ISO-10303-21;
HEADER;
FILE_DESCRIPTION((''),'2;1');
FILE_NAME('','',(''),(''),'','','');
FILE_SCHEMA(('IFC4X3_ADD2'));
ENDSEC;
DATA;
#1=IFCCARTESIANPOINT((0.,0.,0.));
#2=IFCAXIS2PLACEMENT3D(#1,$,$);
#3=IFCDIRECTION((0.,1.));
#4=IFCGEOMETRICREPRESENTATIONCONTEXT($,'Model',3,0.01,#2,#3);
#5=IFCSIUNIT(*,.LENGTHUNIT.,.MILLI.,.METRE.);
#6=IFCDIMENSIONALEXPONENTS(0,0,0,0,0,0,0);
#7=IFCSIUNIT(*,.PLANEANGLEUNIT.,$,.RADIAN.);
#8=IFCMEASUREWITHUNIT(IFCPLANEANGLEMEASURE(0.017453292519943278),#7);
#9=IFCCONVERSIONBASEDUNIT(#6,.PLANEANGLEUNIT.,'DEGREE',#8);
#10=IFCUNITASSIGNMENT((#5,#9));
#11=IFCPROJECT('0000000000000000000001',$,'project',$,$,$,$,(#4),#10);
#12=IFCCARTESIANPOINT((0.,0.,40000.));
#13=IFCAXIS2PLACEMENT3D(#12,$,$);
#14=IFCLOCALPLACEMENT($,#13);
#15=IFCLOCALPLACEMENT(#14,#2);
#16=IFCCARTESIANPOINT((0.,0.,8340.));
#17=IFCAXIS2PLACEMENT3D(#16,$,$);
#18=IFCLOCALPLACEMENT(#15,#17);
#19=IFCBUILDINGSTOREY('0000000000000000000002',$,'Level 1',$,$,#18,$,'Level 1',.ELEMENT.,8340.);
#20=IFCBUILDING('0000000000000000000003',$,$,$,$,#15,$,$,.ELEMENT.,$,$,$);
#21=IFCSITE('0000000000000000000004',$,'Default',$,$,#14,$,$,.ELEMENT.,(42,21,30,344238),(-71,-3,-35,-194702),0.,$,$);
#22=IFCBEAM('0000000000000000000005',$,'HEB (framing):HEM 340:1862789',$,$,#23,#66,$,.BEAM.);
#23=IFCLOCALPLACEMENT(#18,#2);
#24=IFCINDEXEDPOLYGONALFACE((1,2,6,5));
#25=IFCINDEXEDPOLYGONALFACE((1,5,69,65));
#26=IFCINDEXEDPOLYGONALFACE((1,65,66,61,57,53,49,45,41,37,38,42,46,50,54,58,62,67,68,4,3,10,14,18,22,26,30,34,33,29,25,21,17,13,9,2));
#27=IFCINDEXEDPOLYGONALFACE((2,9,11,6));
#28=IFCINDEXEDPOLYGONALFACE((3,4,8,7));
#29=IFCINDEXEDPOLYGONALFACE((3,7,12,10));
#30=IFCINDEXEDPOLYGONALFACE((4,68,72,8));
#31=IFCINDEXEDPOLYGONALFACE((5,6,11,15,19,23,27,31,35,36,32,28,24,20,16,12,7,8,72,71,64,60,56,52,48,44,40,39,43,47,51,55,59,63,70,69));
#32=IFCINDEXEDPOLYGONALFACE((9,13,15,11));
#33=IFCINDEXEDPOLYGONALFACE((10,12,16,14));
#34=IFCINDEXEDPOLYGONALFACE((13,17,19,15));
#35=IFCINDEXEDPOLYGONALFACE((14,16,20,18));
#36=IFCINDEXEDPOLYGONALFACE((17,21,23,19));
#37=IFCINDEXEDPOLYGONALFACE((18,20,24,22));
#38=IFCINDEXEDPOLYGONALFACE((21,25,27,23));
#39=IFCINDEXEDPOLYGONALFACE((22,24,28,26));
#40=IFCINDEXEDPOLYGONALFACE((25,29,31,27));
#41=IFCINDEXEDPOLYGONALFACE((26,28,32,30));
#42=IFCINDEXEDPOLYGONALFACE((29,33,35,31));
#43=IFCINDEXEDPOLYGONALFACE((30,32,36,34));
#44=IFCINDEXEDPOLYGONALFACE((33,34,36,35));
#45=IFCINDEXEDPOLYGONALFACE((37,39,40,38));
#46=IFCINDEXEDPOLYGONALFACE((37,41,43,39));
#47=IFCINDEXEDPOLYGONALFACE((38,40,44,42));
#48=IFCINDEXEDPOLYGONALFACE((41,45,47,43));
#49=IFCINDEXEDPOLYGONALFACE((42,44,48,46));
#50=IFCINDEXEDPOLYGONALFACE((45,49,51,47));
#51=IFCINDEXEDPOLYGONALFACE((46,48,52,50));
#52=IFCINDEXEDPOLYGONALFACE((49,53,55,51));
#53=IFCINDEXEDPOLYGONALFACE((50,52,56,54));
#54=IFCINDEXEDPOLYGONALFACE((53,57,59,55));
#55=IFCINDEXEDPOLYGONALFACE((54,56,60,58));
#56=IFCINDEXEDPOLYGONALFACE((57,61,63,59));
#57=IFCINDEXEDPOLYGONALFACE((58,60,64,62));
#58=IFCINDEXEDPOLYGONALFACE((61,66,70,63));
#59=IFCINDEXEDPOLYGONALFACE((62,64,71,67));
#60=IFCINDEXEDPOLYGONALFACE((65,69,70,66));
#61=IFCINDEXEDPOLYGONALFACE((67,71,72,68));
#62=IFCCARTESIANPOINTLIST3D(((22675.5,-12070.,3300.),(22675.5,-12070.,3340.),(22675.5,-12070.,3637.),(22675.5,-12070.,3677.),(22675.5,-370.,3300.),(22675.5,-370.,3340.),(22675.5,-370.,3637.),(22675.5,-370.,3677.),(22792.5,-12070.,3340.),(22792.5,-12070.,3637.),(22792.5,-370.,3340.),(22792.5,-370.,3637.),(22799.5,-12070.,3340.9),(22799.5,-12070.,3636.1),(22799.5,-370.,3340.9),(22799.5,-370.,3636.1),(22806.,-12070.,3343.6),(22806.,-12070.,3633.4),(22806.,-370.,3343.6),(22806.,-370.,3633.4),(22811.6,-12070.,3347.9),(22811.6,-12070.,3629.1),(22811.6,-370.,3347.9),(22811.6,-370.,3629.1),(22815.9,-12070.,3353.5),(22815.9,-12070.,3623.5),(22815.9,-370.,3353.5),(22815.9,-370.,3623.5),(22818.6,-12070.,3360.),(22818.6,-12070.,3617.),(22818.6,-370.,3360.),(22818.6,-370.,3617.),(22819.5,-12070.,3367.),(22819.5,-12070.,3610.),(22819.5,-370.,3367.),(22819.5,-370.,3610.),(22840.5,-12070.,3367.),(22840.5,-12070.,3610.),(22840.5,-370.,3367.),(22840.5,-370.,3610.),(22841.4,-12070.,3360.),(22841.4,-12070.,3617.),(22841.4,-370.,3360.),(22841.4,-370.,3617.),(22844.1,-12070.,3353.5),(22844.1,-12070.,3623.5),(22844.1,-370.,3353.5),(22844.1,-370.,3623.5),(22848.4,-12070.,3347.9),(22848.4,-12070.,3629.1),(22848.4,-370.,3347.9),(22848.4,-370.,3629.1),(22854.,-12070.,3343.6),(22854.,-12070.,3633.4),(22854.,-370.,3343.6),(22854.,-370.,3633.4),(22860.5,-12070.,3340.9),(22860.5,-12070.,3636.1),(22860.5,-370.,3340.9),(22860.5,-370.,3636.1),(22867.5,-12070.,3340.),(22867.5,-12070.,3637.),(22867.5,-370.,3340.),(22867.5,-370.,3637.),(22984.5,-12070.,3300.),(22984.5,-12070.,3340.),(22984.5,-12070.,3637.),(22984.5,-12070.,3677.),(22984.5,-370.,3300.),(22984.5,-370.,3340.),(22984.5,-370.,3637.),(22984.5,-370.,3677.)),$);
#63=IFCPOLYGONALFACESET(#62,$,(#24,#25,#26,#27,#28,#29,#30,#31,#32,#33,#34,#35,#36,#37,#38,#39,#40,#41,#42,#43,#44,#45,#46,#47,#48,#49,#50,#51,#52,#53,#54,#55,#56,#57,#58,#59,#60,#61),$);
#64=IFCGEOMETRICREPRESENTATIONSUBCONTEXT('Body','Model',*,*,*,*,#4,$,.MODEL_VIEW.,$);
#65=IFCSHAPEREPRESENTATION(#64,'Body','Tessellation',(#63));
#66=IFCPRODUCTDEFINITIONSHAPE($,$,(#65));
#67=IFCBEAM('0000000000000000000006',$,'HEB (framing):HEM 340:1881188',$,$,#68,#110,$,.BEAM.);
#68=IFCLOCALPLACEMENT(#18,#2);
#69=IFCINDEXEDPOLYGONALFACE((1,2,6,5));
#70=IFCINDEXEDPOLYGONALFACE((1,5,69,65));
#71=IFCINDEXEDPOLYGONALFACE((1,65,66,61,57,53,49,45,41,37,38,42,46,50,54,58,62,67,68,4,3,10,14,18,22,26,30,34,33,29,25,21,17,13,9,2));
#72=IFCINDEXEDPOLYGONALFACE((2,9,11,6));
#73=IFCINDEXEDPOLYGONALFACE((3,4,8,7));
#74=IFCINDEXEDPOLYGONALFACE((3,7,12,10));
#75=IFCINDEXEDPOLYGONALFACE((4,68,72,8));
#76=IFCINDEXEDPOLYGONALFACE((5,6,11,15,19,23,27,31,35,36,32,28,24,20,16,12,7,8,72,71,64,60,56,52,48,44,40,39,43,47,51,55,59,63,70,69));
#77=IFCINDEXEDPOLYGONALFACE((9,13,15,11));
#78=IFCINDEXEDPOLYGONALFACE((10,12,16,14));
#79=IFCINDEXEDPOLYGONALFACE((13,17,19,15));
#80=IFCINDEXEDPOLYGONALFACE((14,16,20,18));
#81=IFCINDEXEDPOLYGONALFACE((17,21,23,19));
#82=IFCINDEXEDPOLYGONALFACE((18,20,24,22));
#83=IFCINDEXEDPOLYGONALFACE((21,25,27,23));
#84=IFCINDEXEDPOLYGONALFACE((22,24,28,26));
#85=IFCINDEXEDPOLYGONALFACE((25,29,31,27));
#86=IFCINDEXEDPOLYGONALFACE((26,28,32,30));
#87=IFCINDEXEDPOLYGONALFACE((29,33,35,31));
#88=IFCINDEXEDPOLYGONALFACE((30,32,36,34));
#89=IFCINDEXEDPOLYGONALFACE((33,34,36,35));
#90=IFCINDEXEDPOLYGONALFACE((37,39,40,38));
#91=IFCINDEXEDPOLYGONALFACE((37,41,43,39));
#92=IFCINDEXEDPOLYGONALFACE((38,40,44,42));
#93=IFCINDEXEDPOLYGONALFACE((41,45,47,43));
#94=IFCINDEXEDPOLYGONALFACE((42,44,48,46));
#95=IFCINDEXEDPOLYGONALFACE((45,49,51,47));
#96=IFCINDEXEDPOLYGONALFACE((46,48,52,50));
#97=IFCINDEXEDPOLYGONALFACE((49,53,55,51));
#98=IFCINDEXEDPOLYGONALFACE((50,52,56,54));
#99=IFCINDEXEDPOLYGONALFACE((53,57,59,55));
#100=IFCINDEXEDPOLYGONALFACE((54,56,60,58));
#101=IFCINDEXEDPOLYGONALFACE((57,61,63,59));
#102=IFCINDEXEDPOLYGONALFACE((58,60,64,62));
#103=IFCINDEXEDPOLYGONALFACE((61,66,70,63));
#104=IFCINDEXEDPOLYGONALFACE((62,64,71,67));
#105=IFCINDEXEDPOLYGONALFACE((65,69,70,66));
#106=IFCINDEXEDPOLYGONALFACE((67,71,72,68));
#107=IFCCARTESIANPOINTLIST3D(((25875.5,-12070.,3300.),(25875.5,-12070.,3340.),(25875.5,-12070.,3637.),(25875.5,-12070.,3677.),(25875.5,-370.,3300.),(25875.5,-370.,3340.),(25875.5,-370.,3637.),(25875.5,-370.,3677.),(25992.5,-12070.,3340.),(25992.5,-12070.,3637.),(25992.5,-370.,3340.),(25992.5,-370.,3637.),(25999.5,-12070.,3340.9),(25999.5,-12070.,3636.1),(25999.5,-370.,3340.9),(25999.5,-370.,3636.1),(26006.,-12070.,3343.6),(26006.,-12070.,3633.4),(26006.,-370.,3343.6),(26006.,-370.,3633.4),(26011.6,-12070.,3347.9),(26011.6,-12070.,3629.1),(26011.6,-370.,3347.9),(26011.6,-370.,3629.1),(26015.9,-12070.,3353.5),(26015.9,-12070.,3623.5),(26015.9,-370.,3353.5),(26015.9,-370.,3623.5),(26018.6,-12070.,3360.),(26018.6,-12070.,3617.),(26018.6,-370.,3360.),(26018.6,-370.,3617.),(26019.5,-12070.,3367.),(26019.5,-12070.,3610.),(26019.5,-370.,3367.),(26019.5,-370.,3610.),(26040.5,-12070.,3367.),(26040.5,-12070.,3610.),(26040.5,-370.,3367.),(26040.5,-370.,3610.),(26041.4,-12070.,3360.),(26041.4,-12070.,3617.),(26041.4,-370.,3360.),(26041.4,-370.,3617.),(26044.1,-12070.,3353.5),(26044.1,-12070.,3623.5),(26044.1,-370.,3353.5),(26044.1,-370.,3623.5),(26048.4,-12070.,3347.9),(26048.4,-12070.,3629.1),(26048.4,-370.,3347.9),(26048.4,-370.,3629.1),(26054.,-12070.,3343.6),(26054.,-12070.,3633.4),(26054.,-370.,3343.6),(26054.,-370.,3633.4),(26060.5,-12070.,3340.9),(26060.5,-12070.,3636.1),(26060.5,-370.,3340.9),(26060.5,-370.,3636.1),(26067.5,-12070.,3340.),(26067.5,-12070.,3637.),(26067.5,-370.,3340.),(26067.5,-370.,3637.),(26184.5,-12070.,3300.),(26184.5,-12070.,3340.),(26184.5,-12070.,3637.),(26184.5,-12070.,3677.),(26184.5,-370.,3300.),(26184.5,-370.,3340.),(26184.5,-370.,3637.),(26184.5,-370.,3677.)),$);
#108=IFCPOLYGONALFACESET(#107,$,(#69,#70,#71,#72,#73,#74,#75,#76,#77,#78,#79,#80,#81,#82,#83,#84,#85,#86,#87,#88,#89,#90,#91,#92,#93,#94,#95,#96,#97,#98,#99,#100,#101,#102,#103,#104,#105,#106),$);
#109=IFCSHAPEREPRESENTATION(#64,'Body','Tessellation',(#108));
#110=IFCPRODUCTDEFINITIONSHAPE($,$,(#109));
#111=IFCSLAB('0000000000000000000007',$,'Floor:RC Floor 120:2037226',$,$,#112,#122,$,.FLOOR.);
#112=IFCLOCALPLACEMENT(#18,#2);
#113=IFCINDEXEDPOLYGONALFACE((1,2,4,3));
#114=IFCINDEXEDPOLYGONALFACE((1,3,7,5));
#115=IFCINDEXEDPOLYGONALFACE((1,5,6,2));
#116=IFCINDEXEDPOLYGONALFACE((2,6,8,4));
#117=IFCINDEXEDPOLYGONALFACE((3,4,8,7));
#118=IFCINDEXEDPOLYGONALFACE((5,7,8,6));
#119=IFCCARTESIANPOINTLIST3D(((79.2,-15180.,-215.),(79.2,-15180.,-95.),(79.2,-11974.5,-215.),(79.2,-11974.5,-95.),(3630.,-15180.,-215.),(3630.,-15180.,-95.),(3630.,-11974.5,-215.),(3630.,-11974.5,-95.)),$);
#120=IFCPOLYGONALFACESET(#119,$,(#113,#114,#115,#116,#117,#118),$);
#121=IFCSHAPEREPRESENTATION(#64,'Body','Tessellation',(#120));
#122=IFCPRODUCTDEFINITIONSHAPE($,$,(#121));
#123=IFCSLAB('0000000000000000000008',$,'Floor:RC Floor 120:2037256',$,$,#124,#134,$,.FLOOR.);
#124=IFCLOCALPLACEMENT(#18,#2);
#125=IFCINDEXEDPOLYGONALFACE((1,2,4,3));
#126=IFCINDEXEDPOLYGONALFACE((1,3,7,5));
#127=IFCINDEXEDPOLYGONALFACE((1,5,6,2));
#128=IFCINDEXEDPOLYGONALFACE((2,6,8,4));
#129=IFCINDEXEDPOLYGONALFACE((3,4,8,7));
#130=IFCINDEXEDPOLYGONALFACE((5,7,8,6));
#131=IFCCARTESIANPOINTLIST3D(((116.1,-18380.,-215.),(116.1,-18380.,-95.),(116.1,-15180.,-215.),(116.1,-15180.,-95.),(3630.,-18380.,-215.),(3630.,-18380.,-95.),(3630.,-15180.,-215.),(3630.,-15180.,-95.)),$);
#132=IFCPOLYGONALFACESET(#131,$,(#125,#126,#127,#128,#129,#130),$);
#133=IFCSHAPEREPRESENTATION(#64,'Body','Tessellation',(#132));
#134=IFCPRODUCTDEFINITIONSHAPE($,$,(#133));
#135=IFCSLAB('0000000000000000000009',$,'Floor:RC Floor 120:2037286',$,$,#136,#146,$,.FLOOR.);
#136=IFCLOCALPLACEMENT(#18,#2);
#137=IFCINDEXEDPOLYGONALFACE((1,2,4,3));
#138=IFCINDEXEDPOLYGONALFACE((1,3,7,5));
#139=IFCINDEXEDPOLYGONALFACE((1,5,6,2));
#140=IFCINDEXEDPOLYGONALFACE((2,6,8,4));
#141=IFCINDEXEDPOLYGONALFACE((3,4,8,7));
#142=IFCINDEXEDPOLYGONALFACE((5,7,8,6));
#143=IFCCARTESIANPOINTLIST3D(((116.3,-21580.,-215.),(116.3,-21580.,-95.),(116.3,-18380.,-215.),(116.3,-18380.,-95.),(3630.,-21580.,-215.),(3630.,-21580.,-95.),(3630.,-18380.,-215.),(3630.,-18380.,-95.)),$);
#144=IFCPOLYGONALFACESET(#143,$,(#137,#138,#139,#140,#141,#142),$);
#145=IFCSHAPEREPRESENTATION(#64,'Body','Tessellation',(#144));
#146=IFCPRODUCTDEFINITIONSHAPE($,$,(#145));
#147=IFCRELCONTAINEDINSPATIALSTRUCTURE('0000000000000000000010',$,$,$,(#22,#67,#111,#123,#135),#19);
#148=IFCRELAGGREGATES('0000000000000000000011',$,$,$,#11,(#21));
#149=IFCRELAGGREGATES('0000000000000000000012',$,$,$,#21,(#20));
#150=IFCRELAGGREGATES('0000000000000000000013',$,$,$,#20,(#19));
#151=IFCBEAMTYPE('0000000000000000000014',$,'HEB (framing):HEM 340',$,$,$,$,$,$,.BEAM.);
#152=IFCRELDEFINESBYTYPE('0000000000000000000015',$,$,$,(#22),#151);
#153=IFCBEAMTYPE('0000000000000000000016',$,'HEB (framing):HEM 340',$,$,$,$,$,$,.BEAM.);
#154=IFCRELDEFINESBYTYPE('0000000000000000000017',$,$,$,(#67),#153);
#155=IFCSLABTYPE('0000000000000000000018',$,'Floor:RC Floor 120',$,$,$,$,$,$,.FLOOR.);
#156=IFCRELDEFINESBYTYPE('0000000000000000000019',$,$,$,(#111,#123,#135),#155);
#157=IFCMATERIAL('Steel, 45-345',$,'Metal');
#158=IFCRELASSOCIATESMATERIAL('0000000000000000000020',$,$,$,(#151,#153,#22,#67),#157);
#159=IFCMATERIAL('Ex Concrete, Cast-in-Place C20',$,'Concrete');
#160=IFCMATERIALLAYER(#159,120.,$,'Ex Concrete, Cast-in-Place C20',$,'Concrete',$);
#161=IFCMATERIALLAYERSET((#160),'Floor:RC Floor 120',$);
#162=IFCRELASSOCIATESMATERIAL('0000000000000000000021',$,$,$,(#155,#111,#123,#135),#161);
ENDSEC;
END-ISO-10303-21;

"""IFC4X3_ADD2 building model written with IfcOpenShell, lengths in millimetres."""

from ifc_helpers import new_model, entity, si_unit, converted_unit, direction, frame, frame_2d, origin, origin_2d_with_axis, place, context, subcontext, project, spatial, polyline, circle_curve, parameter, trimmed, segment, composite_curve, rectangle, outline, extrude, source, transform, mapped, material, layer, layer_set, layer_usage, material_profile, profile_set, profile_usage, type_object, type_shapes, element, save


model = new_model("IFC4X3_ADD2")

# Units and contexts
model_context = context("Model", 3, precision=0.01, world=origin(), true_north=direction((0.0, 1.0)))
body_context = subcontext(model_context, "Body", "Model", "MODEL_VIEW")
ifc_project = project(units=[si_unit("LENGTHUNIT", "METRE", prefix="MILLI"), converted_unit("PLANEANGLEUNIT", "DEGREE", entity("IfcPlaneAngleMeasure", 0.017453292519943278), si_unit("PLANEANGLEUNIT", "RADIAN"), dimensions=[0, 0, 0, 0, 0, 0, 0])], contexts=[model_context])

# Site, building, storey
site_placement = place(None, frame((0.0, 0.0, 40000.0)))
site = spatial("IfcSite", under=ifc_project, at=site_placement, Name="Default", CompositionType="ELEMENT", RefLatitude=(42, 21, 30, 344238), RefLongitude=(-71, -3, -35, -194702), RefElevation=0.0)
building_placement = place(site_placement, origin())
building = spatial("IfcBuilding", under=site, at=building_placement, CompositionType="ELEMENT")
storey_placement = place(building_placement, frame((0.0, 0.0, 8340.0)))
storey = spatial("IfcBuildingStorey", under=building, at=storey_placement, Name="Level 1", LongName="Level 1", CompositionType="ELEMENT", Elevation=8340.0)

# Shared definitions
ifc_material_1 = material(Name="Steel, 45-345", Category="Metal")

# Beams
ifc_material_profile_1 = material_profile(ifc_material_1, outline(composite_curve([segment(polyline([(-154.5, -148.5), (-154.5, -188.5)]), True, "CONTINUOUS"), segment(polyline([(-154.5, -188.5), (154.5, -188.5)]), True, "CONTINUOUS"), segment(polyline([(154.5, -188.5), (154.5, -148.5)]), True, "CONTINUOUS"), segment(polyline([(154.5, -148.5), (37.5, -148.5)]), True, "CONTINUOUS"), segment(trimmed(circle_curve(frame_2d((37.5, -121.5), x_axis=(1.0, 0.0)), 27.0), [parameter(180.0)], [parameter(270.0)], True, "PARAMETER"), False, "CONTINUOUS"), segment(polyline([(10.5, -121.5), (10.5, 121.5)]), True, "CONTINUOUS"), segment(trimmed(circle_curve(frame_2d((37.5, 121.5), x_axis=(1.0, 0.0)), 27.0), [parameter(90.0)], [parameter(180.0)], True, "PARAMETER"), False, "CONTINUOUS"), segment(polyline([(37.5, 148.5), (154.5, 148.5)]), True, "CONTINUOUS"), segment(polyline([(154.5, 148.5), (154.5, 188.5)]), True, "CONTINUOUS"), segment(polyline([(154.5, 188.5), (-154.5, 188.5)]), True, "CONTINUOUS"), segment(polyline([(-154.5, 188.5), (-154.5, 148.5)]), True, "CONTINUOUS"), segment(polyline([(-154.5, 148.5), (-37.5, 148.5)]), True, "CONTINUOUS"), segment(trimmed(circle_curve(frame_2d((-37.5, 121.5), x_axis=(1.0, 0.0)), 27.0), [parameter(360.0)], [parameter(90.0)], True, "PARAMETER"), False, "CONTINUOUS"), segment(polyline([(-10.5, 121.5), (-10.5, -121.5)]), True, "CONTINUOUS"), segment(trimmed(circle_curve(frame_2d((-37.5, -121.5), x_axis=(1.0, 0.0)), 27.0), [parameter(270.0)], [parameter(0.0)], True, "PARAMETER"), False, "CONTINUOUS"), segment(polyline([(-37.5, -148.5), (-154.5, -148.5)]), True, "CONTINUOUS")], self_intersect=False)), Name="HEM 340")
ifc_profile_set_1 = profile_set([ifc_material_profile_1], Name="HEM 340")
ifc_profile_usage_1 = profile_usage(ifc_profile_set_1, cardinal=8)
beam_type_1 = type_object("IfcBeamType", Name="HEB (framing):HEM 340", PredefinedType="BEAM", material=ifc_profile_set_1)
shared_shape_1 = source(origin(), body_context, "Body", "SweptSolid", [
    extrude(outline(composite_curve([segment(polyline([(-154.5, -148.5), (-154.5, -188.5)]), True, "CONTINUOUS"), segment(polyline([(-154.5, -188.5), (154.5, -188.5)]), True, "CONTINUOUS"), segment(polyline([(154.5, -188.5), (154.5, -148.5)]), True, "CONTINUOUS"), segment(polyline([(154.5, -148.5), (37.5, -148.5)]), True, "CONTINUOUS"), segment(trimmed(circle_curve(frame_2d((37.5, -121.5), x_axis=(1.0, 0.0)), 27.0), [parameter(180.0)], [parameter(270.0)], True, "PARAMETER"), False, "CONTINUOUS"), segment(polyline([(10.5, -121.5), (10.5, 121.5)]), True, "CONTINUOUS"), segment(trimmed(circle_curve(frame_2d((37.5, 121.5), x_axis=(1.0, 0.0)), 27.0), [parameter(90.0)], [parameter(180.0)], True, "PARAMETER"), False, "CONTINUOUS"), segment(polyline([(37.5, 148.5), (154.5, 148.5)]), True, "CONTINUOUS"), segment(polyline([(154.5, 148.5), (154.5, 188.5)]), True, "CONTINUOUS"), segment(polyline([(154.5, 188.5), (-154.5, 188.5)]), True, "CONTINUOUS"), segment(polyline([(-154.5, 188.5), (-154.5, 148.5)]), True, "CONTINUOUS"), segment(polyline([(-154.5, 148.5), (-37.5, 148.5)]), True, "CONTINUOUS"), segment(trimmed(circle_curve(frame_2d((-37.5, 121.5), x_axis=(1.0, 0.0)), 27.0), [parameter(360.0)], [parameter(90.0)], True, "PARAMETER"), False, "CONTINUOUS"), segment(polyline([(-10.5, 121.5), (-10.5, -121.5)]), True, "CONTINUOUS"), segment(trimmed(circle_curve(frame_2d((-37.5, -121.5), x_axis=(1.0, 0.0)), 27.0), [parameter(270.0)], [parameter(0.0)], True, "PARAMETER"), False, "CONTINUOUS"), segment(polyline([(-37.5, -148.5), (-154.5, -148.5)]), True, "CONTINUOUS")], self_intersect=False)), frame((-5850.0, 0.0, 0.0), z_axis=(-1.0, 0.0, 0.0), x_axis=(0.0, -1.0, 0.0)), (0.0, 0.0, -1.0), 11700.0),
])
type_shapes(beam_type_1, [shared_shape_1])
for number, where, z_axis, x_axis, name in (
    (1, (22830.0, -6220.0, 3488.5), (0.0, 0.0, 1.0), (0.0, -1.0, 0.0), "HEB (framing):HEM 340:1862789"),
):
    element("IfcBeam", number, at=place(storey_placement, frame(where, z_axis=z_axis, x_axis=x_axis)), inside=storey, type_object=beam_type_1, material=ifc_profile_usage_1, Name=name, PredefinedType="BEAM", context=body_context, shape_type="MappedRepresentation", body=[
        mapped(shared_shape_1, transform((0.0, 0.0, 0.0), scale=1.0)),
    ])
beam_type_2 = type_object("IfcBeamType", Name="HEB (framing):HEM 340", PredefinedType="BEAM", material=ifc_profile_set_1)
shared_shape_2 = source(origin(), body_context, "Body", "SweptSolid", [
    extrude(outline(composite_curve([segment(polyline([(-154.5, -148.5), (-154.5, -188.5)]), True, "CONTINUOUS"), segment(polyline([(-154.5, -188.5), (154.5, -188.5)]), True, "CONTINUOUS"), segment(polyline([(154.5, -188.5), (154.5, -148.5)]), True, "CONTINUOUS"), segment(polyline([(154.5, -148.5), (37.5, -148.5)]), True, "CONTINUOUS"), segment(trimmed(circle_curve(frame_2d((37.5, -121.5), x_axis=(1.0, 0.0)), 27.0), [parameter(180.0)], [parameter(270.0)], True, "PARAMETER"), False, "CONTINUOUS"), segment(polyline([(10.5, -121.5), (10.5, 121.5)]), True, "CONTINUOUS"), segment(trimmed(circle_curve(frame_2d((37.5, 121.5), x_axis=(1.0, 0.0)), 27.0), [parameter(90.0)], [parameter(180.0)], True, "PARAMETER"), False, "CONTINUOUS"), segment(polyline([(37.5, 148.5), (154.5, 148.5)]), True, "CONTINUOUS"), segment(polyline([(154.5, 148.5), (154.5, 188.5)]), True, "CONTINUOUS"), segment(polyline([(154.5, 188.5), (-154.5, 188.5)]), True, "CONTINUOUS"), segment(polyline([(-154.5, 188.5), (-154.5, 148.5)]), True, "CONTINUOUS"), segment(polyline([(-154.5, 148.5), (-37.5, 148.5)]), True, "CONTINUOUS"), segment(trimmed(circle_curve(frame_2d((-37.5, 121.5), x_axis=(1.0, 0.0)), 27.0), [parameter(360.0)], [parameter(90.0)], True, "PARAMETER"), False, "CONTINUOUS"), segment(polyline([(-10.5, 121.5), (-10.5, -121.5)]), True, "CONTINUOUS"), segment(trimmed(circle_curve(frame_2d((-37.5, -121.5), x_axis=(1.0, 0.0)), 27.0), [parameter(270.0)], [parameter(0.0)], True, "PARAMETER"), False, "CONTINUOUS"), segment(polyline([(-37.5, -148.5), (-154.5, -148.5)]), True, "CONTINUOUS")], self_intersect=False)), frame((-5850.0, 0.0, 0.0), z_axis=(-1.0, 0.0, 0.0), x_axis=(0.0, -1.0, 0.0)), (0.0, 0.0, -1.0), 11700.0),
])
type_shapes(beam_type_2, [shared_shape_2])
beam_placement = place(storey_placement, frame((26030.0, -6220.0, 3488.5), z_axis=(0.0, 0.0, 1.0), x_axis=(0.0, -1.0, 0.0)))
element("IfcBeam", 2, at=beam_placement, inside=storey, type_object=beam_type_2, material=ifc_profile_usage_1, Name="HEB (framing):HEM 340:1881188", PredefinedType="BEAM", context=body_context, shape_type="MappedRepresentation", body=[
    mapped(shared_shape_2, transform((0.0, 0.0, 0.0), scale=1.0)),
])

# Slabs
ifc_material_2 = material(Name="Ex Concrete, Cast-in-Place C20", Category="Concrete")
ifc_layer_1 = layer(ifc_material_2, 120.0, Name="Ex Concrete, Cast-in-Place C20", Category="Concrete")
ifc_layer_set_1 = layer_set([ifc_layer_1], Name="Floor:RC Floor 120")
ifc_layer_usage_1 = layer_usage(ifc_layer_set_1, "AXIS3", "POSITIVE", 0.0)
slab_type_1 = type_object("IfcSlabType", Name="Floor:RC Floor 120", PredefinedType="FLOOR", material=ifc_layer_set_1)
slab_1_placement = place(storey_placement, origin())
element("IfcSlab", 3, at=slab_1_placement, inside=storey, type_object=slab_type_1, material=ifc_layer_usage_1, Name="Floor:RC Floor 120:2037226", PredefinedType="FLOOR", context=body_context, shape_type="SweptSolid", body=[
    extrude(rectangle(XDim=3205.5, YDim=3550.8, at=frame_2d((0.0, 0.0), x_axis=(1.0, 0.0))), frame((1854.6, -13577.3, -95.0), z_axis=(0.0, 0.0, -1.0), x_axis=(0.0, 1.0, 0.0)), (0.0, 0.0, 1.0), 120.0),
])
ifc_layer_usage_2 = layer_usage(ifc_layer_set_1, "AXIS3", "POSITIVE", 0.0)
slab_2_placement = place(storey_placement, origin())
element("IfcSlab", 4, at=slab_2_placement, inside=storey, type_object=slab_type_1, material=ifc_layer_usage_2, Name="Floor:RC Floor 120:2037256", PredefinedType="FLOOR", context=body_context, shape_type="SweptSolid", body=[
    extrude(rectangle(XDim=3200.0, YDim=3513.9, at=frame_2d((0.0, 0.0), x_axis=(1.0, 0.0))), frame((1873.1, -16780.0, -95.0), z_axis=(0.0, 0.0, -1.0), x_axis=(0.0, 1.0, 0.0)), (0.0, 0.0, 1.0), 120.0),
])
ifc_layer_usage_3 = layer_usage(ifc_layer_set_1, "AXIS3", "POSITIVE", 0.0)
slab_3_placement = place(storey_placement, origin())
element("IfcSlab", 5, at=slab_3_placement, inside=storey, type_object=slab_type_1, material=ifc_layer_usage_3, Name="Floor:RC Floor 120:2037286", PredefinedType="FLOOR", context=body_context, shape_type="SweptSolid", body=[
    extrude(rectangle(XDim=3200.0, YDim=3513.7, at=origin_2d_with_axis()), frame((1873.2, -19980.0, -95.0), z_axis=(0.0, 0.0, -1.0), x_axis=(0.0, 1.0, 0.0)), (0.0, 0.0, 1.0), 120.0),
])

save(model, "model.ifc")
